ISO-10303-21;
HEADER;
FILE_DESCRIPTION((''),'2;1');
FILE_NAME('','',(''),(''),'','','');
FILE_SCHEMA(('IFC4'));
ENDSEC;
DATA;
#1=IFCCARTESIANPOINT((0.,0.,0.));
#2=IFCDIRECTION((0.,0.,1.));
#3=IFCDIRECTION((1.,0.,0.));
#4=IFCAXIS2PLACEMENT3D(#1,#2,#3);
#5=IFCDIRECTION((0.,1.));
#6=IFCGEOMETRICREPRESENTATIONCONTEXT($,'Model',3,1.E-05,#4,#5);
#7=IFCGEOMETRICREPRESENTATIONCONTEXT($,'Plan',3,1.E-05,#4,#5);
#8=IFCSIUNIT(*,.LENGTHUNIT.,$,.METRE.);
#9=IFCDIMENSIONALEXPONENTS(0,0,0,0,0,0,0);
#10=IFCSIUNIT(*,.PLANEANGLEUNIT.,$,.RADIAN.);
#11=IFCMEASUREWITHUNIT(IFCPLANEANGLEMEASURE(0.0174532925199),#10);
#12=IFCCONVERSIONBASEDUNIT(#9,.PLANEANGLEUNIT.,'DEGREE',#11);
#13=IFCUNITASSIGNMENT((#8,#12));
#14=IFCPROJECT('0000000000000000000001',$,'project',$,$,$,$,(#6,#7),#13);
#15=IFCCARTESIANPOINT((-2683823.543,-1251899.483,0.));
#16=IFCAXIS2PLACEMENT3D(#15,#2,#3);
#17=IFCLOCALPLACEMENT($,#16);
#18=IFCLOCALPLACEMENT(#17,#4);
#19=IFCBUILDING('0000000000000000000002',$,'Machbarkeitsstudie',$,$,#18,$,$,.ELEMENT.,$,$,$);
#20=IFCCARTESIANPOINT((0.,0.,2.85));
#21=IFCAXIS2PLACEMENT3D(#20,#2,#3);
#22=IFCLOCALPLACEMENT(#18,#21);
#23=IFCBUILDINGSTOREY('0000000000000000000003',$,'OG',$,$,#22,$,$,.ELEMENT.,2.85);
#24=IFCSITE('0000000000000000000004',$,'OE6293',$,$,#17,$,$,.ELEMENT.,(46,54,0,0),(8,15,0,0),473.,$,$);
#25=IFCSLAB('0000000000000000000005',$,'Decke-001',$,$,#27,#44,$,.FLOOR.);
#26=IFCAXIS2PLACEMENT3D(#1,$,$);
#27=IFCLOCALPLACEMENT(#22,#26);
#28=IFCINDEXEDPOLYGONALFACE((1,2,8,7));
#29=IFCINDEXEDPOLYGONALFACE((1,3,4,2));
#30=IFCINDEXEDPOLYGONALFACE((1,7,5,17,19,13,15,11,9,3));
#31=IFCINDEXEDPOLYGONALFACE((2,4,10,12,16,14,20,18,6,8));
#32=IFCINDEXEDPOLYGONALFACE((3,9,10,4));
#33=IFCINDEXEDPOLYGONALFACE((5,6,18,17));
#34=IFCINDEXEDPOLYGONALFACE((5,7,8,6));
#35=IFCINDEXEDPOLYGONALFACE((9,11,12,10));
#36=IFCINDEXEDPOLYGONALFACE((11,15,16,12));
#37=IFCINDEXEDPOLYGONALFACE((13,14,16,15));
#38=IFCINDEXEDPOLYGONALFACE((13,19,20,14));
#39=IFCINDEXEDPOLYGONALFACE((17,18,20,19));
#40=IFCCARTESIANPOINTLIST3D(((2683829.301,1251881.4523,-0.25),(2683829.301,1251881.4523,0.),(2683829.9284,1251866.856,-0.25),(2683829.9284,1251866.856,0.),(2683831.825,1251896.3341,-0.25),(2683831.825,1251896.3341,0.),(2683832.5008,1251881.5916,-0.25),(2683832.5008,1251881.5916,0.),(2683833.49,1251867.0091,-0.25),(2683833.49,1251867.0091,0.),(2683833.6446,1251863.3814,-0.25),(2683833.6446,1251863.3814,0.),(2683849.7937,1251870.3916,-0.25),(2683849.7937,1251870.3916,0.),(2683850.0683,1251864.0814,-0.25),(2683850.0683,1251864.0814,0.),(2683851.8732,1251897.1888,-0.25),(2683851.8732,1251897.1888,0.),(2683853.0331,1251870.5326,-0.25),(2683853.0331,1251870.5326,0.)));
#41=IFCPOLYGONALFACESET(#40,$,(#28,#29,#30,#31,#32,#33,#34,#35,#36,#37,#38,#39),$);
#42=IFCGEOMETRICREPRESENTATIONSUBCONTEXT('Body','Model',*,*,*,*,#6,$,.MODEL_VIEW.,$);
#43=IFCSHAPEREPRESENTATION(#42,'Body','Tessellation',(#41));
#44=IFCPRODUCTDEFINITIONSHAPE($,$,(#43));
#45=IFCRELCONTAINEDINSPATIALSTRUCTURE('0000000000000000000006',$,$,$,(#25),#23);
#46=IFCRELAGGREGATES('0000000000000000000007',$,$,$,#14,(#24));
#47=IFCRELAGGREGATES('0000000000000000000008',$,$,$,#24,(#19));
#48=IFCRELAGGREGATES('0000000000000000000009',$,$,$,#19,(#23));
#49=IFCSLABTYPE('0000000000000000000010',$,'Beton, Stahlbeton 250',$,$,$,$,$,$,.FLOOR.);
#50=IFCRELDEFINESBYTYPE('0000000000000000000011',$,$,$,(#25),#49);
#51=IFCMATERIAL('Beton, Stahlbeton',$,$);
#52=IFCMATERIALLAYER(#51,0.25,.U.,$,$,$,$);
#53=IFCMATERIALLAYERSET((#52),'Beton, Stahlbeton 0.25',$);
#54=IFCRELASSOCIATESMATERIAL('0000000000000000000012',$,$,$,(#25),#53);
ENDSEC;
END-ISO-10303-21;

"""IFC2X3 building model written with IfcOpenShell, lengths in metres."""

from ifc_helpers import new_model, entity, si_unit, converted_unit, direction, frame, origin_with_axes, place, context, subcontext, project, spatial, polyline, outline, extrude, material, layer, layer_set, layer_usage, type_object, element, save


model = new_model("IFC2X3")

# Units and contexts
model_context = context("Model", 3, precision=1e-05, world=origin_with_axes(), true_north=direction((0.0, 1.0)))
plan_context = context("Plan", 3, precision=1e-05, world=origin_with_axes(), true_north=direction((0.0, 1.0)))
body_context = subcontext(model_context, "Body", "Model", "MODEL_VIEW")
ifc_project = project(units=[si_unit("LENGTHUNIT", "METRE"), converted_unit("PLANEANGLEUNIT", "DEGREE", entity("IfcPlaneAngleMeasure", 0.0174532925199), si_unit("PLANEANGLEUNIT", "RADIAN"), dimensions=[0, 0, 0, 0, 0, 0, 0])], contexts=[model_context, plan_context])

# Site, building, storey
site_placement = place(None, frame((-2683823.543, -1251899.483, 0.0), z_axis=(0.0, 0.0, 1.0), x_axis=(1.0, 0.0, 0.0)))
site = spatial("IfcSite", under=ifc_project, at=site_placement, Name="OE6293", CompositionType="ELEMENT", RefLatitude=(46, 54, 0, 0), RefLongitude=(8, 15, 0, 0), RefElevation=473.0)
building_placement = place(site_placement, origin_with_axes())
building = spatial("IfcBuilding", under=site, at=building_placement, Name="Machbarkeitsstudie", CompositionType="ELEMENT")
storey_placement = place(building_placement, frame((0.0, 0.0, 2.85), z_axis=(0.0, 0.0, 1.0), x_axis=(1.0, 0.0, 0.0)))
storey = spatial("IfcBuildingStorey", under=building, at=storey_placement, Name="OG", CompositionType="ELEMENT", Elevation=2.85)

# Slab
ifc_material = material(Name="Beton, Stahlbeton")
ifc_layer = layer(ifc_material, 0.25, ventilated="UNKNOWN")
ifc_layer_set = layer_set([ifc_layer], Name="Beton, Stahlbeton 0.25")
ifc_layer_usage = layer_usage(ifc_layer_set, "AXIS3", "NEGATIVE", 0.25)
slab_type = type_object("IfcSlabType", Name="Beton, Stahlbeton 250", PredefinedType="FLOOR")
slab_placement = place(storey_placement, frame((2683832.5008, 1251881.5916, 0.0), z_axis=(0.0, 0.0, 1.0), x_axis=(1.0, 0.0, 0.0)))
element("IfcSlab", 1, at=slab_placement, inside=storey, type_object=slab_type, material=ifc_layer_usage, Name="Decke-001", PredefinedType="FLOOR", context=body_context, shape_type="SweptSolid", body=[
    extrude(outline(polyline([(0.0, 0.0), (-3.1998, -0.1392), (-2.5724, -14.7356), (0.9892, -14.5825), (1.1438, -18.2102), (17.5674, -17.5102), (17.2928, -11.2), (20.5323, -11.059), (19.3724, 15.5972), (-0.6758, 14.7426), (0.0, 0.0)])), frame((0.0, 0.0, -0.25), z_axis=(0.0, 0.0, 1.0), x_axis=(1.0, 0.0, 0.0)), (0.0, 0.0, 1.0), 0.25),
])

save(model, "model.ifc")
